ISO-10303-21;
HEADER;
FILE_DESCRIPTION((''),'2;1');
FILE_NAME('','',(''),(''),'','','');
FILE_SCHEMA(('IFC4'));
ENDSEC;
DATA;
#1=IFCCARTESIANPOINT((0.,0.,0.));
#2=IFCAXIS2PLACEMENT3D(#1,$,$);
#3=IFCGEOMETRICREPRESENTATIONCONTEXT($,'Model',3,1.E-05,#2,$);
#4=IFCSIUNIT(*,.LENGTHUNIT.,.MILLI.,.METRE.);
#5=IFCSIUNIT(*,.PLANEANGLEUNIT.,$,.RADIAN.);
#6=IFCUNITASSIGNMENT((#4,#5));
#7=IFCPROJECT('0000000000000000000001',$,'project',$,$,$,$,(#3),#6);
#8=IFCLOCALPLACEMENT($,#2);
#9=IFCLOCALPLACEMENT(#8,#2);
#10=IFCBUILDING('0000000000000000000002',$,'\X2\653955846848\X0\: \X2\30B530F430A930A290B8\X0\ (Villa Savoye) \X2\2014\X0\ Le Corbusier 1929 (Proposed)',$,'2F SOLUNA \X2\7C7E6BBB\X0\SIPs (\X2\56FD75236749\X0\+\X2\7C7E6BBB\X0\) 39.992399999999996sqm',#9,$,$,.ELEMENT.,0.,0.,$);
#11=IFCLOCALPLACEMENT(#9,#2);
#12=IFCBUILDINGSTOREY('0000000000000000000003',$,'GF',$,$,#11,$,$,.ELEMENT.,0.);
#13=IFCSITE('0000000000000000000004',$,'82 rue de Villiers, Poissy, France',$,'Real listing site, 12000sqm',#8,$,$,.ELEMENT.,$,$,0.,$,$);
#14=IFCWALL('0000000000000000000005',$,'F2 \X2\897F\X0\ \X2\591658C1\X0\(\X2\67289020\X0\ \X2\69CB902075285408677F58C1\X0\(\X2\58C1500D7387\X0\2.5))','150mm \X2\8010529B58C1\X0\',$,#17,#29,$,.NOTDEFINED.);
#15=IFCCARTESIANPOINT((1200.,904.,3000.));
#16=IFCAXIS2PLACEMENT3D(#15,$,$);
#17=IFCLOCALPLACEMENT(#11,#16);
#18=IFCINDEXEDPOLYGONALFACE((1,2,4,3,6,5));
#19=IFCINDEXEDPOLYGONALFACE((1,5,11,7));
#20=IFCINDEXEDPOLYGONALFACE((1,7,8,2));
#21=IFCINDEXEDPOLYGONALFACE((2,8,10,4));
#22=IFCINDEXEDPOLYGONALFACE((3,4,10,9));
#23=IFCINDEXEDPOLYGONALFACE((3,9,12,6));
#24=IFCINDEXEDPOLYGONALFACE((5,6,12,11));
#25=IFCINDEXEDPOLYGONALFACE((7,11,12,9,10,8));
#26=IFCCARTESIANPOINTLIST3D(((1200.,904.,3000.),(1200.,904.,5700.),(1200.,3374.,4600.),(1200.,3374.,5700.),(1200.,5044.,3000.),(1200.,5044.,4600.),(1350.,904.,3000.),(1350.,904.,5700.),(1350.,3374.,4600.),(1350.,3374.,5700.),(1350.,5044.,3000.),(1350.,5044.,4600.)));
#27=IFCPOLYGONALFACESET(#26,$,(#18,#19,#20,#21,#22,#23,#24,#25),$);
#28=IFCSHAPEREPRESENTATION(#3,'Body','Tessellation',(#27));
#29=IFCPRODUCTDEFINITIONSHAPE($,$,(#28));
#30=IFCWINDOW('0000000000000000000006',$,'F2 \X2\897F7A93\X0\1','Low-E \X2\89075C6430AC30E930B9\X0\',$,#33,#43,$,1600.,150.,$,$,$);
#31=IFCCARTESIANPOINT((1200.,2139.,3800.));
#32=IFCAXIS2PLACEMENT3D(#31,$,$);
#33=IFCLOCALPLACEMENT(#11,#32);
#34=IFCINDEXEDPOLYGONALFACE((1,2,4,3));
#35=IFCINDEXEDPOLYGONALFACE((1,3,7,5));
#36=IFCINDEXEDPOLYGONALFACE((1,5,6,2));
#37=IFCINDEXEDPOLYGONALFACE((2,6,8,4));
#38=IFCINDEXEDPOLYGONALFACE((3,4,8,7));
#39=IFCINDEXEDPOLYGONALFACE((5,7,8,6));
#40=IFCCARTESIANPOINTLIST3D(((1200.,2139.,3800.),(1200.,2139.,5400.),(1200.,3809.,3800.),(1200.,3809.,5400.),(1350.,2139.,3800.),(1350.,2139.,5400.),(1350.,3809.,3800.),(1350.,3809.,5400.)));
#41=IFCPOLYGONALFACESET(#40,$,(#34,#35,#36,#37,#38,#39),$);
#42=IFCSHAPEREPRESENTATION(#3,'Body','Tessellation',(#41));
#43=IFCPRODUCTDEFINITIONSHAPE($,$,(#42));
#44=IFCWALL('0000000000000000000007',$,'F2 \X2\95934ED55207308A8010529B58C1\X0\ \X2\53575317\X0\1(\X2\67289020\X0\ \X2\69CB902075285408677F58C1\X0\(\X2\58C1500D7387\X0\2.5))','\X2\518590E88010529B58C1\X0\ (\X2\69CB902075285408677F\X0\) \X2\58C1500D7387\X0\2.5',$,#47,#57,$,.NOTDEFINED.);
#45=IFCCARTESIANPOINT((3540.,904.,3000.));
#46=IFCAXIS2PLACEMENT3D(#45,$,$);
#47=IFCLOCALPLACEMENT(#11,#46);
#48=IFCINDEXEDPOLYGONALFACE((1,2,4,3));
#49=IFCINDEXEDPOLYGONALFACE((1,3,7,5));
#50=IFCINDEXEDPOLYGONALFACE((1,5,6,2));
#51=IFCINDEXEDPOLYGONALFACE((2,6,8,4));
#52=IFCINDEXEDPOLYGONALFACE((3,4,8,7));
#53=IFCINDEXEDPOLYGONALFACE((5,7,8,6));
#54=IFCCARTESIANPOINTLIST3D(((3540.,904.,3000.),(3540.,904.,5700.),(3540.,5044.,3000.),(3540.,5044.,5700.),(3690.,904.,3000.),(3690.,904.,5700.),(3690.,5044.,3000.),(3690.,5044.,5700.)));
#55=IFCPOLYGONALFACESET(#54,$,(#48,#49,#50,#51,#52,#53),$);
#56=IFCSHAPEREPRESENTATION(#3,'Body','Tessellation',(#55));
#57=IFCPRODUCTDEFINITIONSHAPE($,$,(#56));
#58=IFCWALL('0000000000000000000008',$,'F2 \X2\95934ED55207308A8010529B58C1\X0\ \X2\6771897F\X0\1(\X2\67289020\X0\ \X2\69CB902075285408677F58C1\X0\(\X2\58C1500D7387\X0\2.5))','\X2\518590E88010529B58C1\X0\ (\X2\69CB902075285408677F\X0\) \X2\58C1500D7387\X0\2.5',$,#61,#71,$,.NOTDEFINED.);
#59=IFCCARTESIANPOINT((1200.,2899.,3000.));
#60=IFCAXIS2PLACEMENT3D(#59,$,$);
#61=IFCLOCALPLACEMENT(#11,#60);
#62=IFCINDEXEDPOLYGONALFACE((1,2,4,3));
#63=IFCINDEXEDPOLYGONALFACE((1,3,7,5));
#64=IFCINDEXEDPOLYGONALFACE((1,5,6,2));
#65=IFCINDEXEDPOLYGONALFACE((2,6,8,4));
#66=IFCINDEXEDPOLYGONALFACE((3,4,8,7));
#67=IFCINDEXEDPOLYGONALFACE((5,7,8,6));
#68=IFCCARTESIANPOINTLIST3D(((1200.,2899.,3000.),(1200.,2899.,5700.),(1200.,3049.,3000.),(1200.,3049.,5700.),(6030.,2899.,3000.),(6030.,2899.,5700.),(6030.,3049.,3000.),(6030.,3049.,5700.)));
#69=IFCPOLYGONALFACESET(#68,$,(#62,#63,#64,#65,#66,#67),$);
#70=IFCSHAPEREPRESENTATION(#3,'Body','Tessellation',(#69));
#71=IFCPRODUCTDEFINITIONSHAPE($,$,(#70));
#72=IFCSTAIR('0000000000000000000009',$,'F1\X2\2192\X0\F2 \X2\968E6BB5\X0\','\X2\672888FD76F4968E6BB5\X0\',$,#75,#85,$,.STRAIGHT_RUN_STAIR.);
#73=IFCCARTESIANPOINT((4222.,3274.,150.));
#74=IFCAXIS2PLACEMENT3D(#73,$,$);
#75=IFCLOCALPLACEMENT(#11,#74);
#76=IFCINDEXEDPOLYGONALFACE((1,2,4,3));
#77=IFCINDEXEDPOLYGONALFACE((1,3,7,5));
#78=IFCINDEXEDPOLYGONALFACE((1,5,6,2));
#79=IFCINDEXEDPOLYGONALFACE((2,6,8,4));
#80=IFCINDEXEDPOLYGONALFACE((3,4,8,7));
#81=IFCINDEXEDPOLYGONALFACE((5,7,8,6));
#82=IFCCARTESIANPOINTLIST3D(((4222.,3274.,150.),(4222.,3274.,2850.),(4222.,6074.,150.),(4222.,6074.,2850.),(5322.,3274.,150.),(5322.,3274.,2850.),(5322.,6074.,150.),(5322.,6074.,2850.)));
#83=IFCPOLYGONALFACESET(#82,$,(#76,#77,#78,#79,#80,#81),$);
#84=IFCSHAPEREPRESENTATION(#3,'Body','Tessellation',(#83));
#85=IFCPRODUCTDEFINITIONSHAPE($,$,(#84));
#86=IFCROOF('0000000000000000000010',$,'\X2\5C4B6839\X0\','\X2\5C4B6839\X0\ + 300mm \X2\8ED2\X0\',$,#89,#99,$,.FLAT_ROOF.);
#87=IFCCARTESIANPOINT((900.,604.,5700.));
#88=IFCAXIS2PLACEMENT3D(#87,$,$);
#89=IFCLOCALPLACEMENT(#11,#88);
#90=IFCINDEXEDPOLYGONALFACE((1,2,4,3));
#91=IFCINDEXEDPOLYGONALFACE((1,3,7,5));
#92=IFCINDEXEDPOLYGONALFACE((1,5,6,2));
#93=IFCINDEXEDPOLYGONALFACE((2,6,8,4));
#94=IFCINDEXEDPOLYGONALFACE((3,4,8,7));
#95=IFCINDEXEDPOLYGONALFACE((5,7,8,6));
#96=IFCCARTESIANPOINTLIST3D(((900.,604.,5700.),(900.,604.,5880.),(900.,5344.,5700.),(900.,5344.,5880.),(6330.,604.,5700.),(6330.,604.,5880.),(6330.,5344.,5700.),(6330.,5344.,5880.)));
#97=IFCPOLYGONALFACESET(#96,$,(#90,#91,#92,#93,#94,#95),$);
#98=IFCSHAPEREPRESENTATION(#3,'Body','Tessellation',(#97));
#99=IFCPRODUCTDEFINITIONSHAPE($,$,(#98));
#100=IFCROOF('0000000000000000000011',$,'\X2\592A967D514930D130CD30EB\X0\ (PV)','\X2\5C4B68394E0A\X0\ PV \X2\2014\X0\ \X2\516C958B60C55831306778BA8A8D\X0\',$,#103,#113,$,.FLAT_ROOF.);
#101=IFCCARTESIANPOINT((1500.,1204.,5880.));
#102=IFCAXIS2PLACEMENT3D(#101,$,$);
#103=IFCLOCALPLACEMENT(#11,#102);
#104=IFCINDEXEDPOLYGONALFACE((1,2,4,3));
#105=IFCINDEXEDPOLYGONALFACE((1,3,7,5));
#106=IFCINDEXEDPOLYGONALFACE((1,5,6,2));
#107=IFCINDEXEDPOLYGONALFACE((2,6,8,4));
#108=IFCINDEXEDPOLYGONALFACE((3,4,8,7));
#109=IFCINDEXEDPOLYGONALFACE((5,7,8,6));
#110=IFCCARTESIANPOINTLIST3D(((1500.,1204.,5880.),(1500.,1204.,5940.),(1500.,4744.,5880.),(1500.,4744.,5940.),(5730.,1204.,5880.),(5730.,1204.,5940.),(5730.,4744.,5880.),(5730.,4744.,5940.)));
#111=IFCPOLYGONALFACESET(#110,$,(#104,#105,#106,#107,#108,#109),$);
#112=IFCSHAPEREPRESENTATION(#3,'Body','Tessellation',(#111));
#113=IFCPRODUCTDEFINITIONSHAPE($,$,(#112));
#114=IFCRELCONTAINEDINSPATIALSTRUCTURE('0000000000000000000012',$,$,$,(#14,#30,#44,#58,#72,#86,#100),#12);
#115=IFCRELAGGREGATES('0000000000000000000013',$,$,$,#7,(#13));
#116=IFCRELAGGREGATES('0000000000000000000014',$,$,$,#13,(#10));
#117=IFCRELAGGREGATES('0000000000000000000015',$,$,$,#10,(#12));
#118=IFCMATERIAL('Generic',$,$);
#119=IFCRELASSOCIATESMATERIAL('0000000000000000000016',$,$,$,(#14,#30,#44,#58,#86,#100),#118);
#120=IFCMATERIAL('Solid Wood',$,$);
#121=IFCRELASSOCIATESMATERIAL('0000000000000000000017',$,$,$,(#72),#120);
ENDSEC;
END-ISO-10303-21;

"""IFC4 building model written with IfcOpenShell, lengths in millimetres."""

from ifc_helpers import new_model, si_unit, frame, frame_2d, origin, place, context, project, spatial, rectangle, extrude, material, element, fill, save


model = new_model("IFC4")

# Units and contexts
model_context = context("Model", 3, precision=1e-05, world=origin())
ifc_project = project(units=[si_unit("LENGTHUNIT", "METRE", prefix="MILLI"), si_unit("PLANEANGLEUNIT", "RADIAN")], contexts=[model_context])

# Site, building, storey
site_placement = place(None, origin())
site = spatial("IfcSite", under=ifc_project, at=site_placement, Name="82 rue de Villiers, Poissy, France", ObjectType="Real listing site, 12000sqm", CompositionType="ELEMENT", RefElevation=0.0)
building_placement = place(site_placement, origin())
building = spatial("IfcBuilding", under=site, at=building_placement, Name="改善案: サヴォア邸 (Villa Savoye) — Le Corbusier 1929 (Proposed)", ObjectType="2F SOLUNA 籾殻SIPs (国産杉+籾殻) 39.992399999999996sqm", CompositionType="ELEMENT", ElevationOfRefHeight=0.0, ElevationOfTerrain=0.0)
storey_placement = place(building_placement, origin())
storey = spatial("IfcBuildingStorey", under=building, at=storey_placement, Name="GF", CompositionType="ELEMENT", Elevation=0.0)

# Shared definitions
ifc_material_1 = material(Name="Generic")

# Shared definitions
ifc_material_2 = material(Name="Solid Wood")

# Wall, opening, window
wall_1_placement = place(storey_placement, frame((1200.0, 904.0, 3000.0)))
wall_1 = element("IfcWall", 1, at=wall_1_placement, inside=storey, material=ifc_material_1, Name="F2 西 外壁(木造 構造用合板壁(壁倍率2.5))", Description="150mm 耐力壁", PredefinedType="NOTDEFINED", context=model_context, shape_type="SweptSolid", body=[
    extrude(rectangle(XDim=150.0, YDim=4140.0, at=frame_2d((75.0, 2070.0))), frame((1200.0, 904.0, 3000.0)), (0.0, 0.0, 1.0), 2700.0),
])
opening_1_placement = place(storey_placement, frame((1200.0, 2139.0, 3800.0)))
opening_1 = element("IfcOpeningElement", 2, at=opening_1_placement, cuts=wall_1, PredefinedType="NOTDEFINED", context=model_context, shape_type="SweptSolid", body=[
    extrude(rectangle(XDim=150.0, YDim=1670.0, at=frame_2d((75.0, 835.0))), frame((1200.0, 2139.0, 3800.0)), (0.0, 0.0, 1.0), 1600.0),
])
window_1_placement = place(storey_placement, frame((1200.0, 2139.0, 3800.0)))
window_1 = element("IfcWindow", 3, at=window_1_placement, inside=storey, material=ifc_material_1, Name="F2 西窓1", Description="Low-E 複層ガラス", OverallHeight=1600.0, OverallWidth=150.0, context=model_context, shape_type="SweptSolid", body=[
    extrude(rectangle(XDim=150.0, YDim=1670.0, at=frame_2d((75.0, 835.0))), frame((1200.0, 2139.0, 3800.0)), (0.0, 0.0, 1.0), 1600.0),
])
fill(opening_1, window_1)

# Walls
wall_2_placement = place(storey_placement, frame((3540.0, 904.0, 3000.0)))
element("IfcWall", 4, at=wall_2_placement, inside=storey, material=ifc_material_1, Name="F2 間仕切り耐力壁 南北1(木造 構造用合板壁(壁倍率2.5))", Description="内部耐力壁 (構造用合板) 壁倍率2.5", PredefinedType="NOTDEFINED", context=model_context, shape_type="SweptSolid", body=[
    extrude(rectangle(XDim=150.0, YDim=4140.0, at=frame_2d((75.0, 2070.0))), frame((3540.0, 904.0, 3000.0)), (0.0, 0.0, 1.0), 2700.0),
])
wall_3_placement = place(storey_placement, frame((1200.0, 2899.0, 3000.0)))
element("IfcWall", 5, at=wall_3_placement, inside=storey, material=ifc_material_1, Name="F2 間仕切り耐力壁 東西1(木造 構造用合板壁(壁倍率2.5))", Description="内部耐力壁 (構造用合板) 壁倍率2.5", PredefinedType="NOTDEFINED", context=model_context, shape_type="SweptSolid", body=[
    extrude(rectangle(XDim=4830.0, YDim=150.0, at=frame_2d((2415.0, 75.0))), frame((1200.0, 2899.0, 3000.0)), (0.0, 0.0, 1.0), 2700.0),
])

# Stair
stair_placement = place(storey_placement, frame((4222.0, 3274.0, 150.0)))
element("IfcStair", 6, at=stair_placement, inside=storey, material=ifc_material_2, Name="F1→F2 階段", Description="木製直階段", PredefinedType="STRAIGHT_RUN_STAIR", context=model_context, shape_type="SweptSolid", body=[
    extrude(rectangle(XDim=1100.0, YDim=2800.0, at=frame_2d((550.0, 1400.0))), frame((4222.0, 3274.0, 150.0)), (0.0, 0.0, 1.0), 2700.0),
])

# Roofs
roof_1_placement = place(storey_placement, frame((900.0, 604.0, 5700.0)))
element("IfcRoof", 7, at=roof_1_placement, inside=storey, material=ifc_material_1, Name="屋根", Description="屋根 + 300mm 軒", PredefinedType="FLAT_ROOF", context=model_context, shape_type="SweptSolid", body=[
    extrude(rectangle(XDim=5430.0, YDim=4740.0, at=frame_2d((2715.0, 2370.0))), frame((900.0, 604.0, 5700.0)), (0.0, 0.0, 1.0), 180.0),
])
roof_2_placement = place(storey_placement, frame((1500.0, 1204.0, 5880.0)))
element("IfcRoof", 8, at=roof_2_placement, inside=storey, material=ifc_material_1, Name="太陽光パネル (PV)", Description="屋根上 PV — 公開情報で確認", PredefinedType="FLAT_ROOF", context=model_context, shape_type="SweptSolid", body=[
    extrude(rectangle(XDim=4230.0, YDim=3540.0, at=frame_2d((2115.0, 1770.0))), frame((1500.0, 1204.0, 5880.0)), (0.0, 0.0, 1.0), 60.0),
])

save(model, "model.ifc")
